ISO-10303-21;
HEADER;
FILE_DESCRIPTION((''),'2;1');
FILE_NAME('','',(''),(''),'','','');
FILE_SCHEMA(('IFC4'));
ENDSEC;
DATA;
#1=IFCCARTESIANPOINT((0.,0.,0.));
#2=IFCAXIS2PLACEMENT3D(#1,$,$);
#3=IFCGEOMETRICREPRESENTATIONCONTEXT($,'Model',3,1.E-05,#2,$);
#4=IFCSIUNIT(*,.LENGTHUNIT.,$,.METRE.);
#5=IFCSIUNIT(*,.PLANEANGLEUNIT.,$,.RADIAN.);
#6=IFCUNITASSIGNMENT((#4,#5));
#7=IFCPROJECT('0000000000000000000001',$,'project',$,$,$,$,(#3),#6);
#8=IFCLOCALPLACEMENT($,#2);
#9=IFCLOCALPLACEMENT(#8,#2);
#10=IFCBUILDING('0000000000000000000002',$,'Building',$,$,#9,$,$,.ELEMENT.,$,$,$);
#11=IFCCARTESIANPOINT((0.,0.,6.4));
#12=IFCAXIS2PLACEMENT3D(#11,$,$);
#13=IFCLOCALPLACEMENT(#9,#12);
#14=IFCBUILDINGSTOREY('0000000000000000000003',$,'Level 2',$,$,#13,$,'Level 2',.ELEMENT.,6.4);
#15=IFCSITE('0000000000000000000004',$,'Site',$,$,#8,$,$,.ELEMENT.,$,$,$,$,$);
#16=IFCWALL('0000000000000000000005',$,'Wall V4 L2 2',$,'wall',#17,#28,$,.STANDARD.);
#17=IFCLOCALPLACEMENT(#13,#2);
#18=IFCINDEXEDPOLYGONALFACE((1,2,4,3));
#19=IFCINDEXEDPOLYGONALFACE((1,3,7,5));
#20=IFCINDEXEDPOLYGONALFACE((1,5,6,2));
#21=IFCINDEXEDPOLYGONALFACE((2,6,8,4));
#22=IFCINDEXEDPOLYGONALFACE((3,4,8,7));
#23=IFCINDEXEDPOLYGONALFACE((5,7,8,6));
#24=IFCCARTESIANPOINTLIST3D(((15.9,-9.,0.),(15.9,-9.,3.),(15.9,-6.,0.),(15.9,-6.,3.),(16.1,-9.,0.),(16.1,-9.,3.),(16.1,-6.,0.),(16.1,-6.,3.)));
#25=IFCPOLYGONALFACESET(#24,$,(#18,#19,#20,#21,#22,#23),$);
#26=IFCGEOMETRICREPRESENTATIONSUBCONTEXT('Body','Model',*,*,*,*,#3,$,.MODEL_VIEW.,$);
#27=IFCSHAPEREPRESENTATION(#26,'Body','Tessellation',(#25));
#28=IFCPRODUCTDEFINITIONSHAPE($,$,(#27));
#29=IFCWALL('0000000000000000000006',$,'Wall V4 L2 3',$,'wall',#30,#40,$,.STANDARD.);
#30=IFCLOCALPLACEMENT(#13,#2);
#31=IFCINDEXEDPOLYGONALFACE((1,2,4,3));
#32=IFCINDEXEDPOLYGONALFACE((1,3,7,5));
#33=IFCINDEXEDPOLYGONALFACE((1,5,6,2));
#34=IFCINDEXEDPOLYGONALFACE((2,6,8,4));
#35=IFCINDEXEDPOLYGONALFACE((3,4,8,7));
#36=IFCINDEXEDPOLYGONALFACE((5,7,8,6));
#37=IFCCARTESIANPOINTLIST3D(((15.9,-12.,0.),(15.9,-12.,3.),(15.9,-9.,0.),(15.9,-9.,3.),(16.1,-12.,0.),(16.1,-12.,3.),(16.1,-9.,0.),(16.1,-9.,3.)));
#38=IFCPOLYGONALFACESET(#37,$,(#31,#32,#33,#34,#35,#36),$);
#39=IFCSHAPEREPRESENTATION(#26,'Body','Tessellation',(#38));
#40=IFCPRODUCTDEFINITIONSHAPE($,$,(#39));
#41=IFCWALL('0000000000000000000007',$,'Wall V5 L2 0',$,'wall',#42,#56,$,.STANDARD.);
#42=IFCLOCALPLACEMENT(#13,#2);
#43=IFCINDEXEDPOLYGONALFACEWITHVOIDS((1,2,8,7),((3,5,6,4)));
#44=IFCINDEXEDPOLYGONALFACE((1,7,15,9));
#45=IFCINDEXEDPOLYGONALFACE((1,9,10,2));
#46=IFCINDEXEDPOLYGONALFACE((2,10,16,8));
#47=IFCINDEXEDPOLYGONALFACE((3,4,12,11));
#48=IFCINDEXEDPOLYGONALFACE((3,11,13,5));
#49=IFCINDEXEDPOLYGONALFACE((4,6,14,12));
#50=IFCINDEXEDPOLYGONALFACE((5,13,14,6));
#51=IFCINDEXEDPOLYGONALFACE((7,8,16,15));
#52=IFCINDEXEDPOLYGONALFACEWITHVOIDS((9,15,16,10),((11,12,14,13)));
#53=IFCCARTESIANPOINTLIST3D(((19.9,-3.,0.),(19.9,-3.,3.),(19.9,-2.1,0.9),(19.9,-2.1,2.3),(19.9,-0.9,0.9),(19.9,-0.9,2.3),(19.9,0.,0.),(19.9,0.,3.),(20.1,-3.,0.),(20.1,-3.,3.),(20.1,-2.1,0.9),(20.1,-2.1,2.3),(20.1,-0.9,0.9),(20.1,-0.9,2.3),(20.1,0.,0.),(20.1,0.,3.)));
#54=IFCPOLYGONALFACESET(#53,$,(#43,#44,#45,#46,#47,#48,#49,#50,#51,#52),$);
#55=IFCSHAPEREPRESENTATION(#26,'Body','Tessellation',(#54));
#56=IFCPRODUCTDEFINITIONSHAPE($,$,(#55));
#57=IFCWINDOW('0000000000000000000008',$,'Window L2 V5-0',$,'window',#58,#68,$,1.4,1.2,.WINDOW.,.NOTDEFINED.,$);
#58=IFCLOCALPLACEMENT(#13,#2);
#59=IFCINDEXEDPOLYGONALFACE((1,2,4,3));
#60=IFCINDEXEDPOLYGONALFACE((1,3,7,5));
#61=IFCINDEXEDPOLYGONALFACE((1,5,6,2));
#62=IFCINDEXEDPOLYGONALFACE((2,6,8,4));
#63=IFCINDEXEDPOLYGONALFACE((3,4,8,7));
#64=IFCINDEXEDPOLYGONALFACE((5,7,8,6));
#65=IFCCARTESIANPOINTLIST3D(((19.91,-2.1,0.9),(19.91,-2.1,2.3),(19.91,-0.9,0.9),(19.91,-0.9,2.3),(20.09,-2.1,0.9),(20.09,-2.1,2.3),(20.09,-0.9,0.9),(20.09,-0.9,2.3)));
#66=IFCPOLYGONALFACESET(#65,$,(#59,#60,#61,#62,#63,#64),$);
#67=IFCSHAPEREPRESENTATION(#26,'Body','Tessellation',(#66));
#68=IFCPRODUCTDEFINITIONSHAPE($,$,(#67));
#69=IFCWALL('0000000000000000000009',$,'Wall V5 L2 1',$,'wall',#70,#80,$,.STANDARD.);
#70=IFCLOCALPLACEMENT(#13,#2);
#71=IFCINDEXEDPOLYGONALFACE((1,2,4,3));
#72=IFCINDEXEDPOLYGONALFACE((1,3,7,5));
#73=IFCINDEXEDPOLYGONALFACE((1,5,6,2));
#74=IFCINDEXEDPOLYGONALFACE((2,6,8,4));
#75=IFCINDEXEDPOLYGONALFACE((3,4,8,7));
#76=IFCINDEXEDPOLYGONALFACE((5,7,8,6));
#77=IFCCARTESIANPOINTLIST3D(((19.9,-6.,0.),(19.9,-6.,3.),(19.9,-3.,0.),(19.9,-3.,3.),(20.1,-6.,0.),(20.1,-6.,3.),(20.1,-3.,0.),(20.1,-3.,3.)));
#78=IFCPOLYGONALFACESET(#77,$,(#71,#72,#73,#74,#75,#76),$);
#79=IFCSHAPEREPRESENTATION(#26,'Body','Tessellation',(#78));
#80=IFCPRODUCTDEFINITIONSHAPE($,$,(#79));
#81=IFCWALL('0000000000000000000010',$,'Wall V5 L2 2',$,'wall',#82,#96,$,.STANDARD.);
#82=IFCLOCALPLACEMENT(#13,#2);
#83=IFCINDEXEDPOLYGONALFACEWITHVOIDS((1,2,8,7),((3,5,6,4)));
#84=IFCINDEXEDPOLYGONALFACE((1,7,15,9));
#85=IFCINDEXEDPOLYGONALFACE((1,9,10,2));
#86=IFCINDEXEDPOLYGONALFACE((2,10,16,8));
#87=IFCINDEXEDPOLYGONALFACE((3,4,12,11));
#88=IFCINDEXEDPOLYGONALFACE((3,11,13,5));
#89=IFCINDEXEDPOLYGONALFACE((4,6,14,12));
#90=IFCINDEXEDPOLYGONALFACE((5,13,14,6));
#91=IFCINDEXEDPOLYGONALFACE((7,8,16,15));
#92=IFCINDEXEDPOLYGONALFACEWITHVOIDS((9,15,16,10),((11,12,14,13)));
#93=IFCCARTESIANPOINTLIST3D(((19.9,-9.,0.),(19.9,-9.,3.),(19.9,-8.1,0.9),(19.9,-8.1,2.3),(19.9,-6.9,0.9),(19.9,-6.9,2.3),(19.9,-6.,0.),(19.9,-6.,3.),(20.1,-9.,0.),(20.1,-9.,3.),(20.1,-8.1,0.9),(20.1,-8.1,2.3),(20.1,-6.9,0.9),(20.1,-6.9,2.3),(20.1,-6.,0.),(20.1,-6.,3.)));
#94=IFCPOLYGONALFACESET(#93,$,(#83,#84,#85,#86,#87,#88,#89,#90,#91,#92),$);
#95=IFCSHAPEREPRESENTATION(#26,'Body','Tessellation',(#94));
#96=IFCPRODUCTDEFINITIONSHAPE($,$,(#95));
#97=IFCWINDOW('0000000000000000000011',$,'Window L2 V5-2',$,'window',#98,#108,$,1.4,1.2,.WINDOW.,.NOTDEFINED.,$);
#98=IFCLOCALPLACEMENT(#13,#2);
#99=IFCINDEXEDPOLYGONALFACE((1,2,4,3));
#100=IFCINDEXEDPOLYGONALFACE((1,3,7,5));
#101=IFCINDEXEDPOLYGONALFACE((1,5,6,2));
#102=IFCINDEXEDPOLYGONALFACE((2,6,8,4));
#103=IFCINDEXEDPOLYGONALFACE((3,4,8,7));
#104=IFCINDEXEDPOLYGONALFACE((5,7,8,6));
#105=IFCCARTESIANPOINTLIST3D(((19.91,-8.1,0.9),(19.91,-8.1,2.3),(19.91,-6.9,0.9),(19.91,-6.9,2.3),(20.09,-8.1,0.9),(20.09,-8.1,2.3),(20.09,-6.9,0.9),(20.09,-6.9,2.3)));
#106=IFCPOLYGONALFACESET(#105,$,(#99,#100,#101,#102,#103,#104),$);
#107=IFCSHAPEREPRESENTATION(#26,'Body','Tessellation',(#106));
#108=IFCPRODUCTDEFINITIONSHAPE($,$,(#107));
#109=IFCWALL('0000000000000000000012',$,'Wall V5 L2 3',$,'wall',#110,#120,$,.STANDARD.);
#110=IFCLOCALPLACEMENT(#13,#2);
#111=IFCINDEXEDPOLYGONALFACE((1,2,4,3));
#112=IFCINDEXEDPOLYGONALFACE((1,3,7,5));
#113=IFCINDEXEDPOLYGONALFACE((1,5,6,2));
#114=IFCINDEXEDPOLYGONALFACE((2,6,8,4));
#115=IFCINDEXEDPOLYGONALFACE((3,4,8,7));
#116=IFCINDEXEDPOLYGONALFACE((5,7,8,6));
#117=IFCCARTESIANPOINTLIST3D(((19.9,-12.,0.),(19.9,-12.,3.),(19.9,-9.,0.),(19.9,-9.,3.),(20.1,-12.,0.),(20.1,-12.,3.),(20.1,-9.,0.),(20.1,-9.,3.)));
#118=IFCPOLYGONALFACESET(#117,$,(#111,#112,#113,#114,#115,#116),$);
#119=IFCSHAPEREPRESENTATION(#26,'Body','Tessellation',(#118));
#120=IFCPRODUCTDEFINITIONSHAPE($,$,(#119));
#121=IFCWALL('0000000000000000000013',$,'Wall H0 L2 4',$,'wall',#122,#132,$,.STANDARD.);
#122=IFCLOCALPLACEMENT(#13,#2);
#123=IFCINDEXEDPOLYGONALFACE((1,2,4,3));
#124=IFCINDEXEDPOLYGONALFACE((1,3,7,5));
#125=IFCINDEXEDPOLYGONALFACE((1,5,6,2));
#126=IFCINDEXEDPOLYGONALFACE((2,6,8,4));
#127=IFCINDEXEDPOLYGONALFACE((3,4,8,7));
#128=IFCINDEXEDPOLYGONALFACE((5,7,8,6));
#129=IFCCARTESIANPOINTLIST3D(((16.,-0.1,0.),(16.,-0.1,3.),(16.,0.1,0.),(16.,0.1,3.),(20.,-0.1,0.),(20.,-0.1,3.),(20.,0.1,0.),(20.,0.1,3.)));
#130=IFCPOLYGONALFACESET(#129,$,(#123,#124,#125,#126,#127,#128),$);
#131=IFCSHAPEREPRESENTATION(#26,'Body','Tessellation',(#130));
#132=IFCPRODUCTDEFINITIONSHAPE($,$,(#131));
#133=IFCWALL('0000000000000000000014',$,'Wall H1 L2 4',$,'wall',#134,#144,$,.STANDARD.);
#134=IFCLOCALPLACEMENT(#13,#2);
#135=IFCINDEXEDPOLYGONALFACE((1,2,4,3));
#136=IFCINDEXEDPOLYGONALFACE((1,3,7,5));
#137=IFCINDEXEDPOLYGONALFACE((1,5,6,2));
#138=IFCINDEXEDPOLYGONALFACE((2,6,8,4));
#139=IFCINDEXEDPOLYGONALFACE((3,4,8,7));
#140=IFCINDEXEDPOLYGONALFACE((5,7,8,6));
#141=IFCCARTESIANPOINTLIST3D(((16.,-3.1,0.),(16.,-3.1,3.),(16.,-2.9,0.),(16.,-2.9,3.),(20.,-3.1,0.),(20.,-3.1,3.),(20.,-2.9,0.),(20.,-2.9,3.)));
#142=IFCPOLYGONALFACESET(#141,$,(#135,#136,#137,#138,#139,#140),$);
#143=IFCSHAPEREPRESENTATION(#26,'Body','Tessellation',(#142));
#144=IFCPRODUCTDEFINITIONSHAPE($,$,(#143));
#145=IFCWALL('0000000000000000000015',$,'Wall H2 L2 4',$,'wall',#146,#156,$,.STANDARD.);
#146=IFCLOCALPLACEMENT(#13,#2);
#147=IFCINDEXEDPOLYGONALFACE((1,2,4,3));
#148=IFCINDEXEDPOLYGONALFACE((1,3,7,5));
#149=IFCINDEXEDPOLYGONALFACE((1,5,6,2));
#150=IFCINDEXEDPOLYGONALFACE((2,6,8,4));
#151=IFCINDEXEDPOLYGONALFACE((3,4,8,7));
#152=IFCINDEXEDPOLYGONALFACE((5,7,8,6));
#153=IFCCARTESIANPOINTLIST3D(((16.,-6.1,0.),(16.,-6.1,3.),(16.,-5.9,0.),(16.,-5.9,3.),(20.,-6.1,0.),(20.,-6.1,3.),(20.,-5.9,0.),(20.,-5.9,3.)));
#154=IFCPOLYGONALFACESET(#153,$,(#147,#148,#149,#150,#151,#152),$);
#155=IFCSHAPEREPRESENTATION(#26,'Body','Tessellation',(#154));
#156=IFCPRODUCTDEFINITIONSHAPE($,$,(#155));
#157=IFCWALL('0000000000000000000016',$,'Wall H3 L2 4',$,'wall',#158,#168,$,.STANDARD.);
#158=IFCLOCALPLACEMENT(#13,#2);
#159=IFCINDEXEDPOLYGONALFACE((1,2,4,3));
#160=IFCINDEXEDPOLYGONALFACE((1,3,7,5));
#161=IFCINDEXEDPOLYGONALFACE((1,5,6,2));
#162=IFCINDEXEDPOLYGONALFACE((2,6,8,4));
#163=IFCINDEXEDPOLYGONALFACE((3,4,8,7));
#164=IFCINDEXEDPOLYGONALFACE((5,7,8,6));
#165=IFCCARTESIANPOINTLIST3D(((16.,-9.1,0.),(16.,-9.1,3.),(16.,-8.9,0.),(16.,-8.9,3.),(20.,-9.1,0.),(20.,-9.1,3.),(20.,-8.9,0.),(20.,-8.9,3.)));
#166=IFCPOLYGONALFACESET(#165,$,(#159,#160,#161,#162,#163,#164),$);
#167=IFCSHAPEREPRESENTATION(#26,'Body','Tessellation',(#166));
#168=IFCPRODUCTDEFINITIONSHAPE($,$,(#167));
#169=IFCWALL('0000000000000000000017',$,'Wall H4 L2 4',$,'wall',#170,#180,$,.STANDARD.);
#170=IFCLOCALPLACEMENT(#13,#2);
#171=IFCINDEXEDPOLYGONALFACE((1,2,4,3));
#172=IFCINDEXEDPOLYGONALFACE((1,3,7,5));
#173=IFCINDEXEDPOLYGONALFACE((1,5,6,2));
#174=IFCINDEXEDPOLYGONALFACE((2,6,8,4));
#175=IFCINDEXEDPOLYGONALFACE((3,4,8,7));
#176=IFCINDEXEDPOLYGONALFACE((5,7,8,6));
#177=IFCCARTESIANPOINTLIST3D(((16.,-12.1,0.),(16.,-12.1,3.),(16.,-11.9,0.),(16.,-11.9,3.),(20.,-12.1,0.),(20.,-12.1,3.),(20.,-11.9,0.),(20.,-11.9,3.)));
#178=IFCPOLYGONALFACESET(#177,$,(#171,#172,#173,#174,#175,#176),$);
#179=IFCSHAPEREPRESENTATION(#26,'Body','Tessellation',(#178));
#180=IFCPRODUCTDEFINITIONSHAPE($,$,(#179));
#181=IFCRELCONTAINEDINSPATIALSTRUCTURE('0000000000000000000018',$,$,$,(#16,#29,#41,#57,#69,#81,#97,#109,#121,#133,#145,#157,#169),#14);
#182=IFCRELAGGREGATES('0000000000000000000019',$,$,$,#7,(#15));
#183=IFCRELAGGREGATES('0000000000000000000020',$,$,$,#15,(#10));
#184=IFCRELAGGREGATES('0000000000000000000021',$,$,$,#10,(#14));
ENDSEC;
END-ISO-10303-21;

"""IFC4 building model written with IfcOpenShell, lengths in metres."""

from ifc_helpers import new_model, si_unit, frame, frame_2d, origin, origin_2d, place, context, subcontext, project, spatial, rectangle, extrude, element, fill, save


model = new_model("IFC4")

# Units and contexts
model_context = context("Model", 3, precision=1e-05, world=origin())
body_context = subcontext(model_context, "Body", "Model", "MODEL_VIEW")
ifc_project = project(units=[si_unit("LENGTHUNIT", "METRE"), si_unit("PLANEANGLEUNIT", "RADIAN")], contexts=[model_context])

# Site, building, storey
site_placement = place(None, origin())
site = spatial("IfcSite", under=ifc_project, at=site_placement, Name="Site", CompositionType="ELEMENT")
building_placement = place(site_placement, origin())
building = spatial("IfcBuilding", under=site, at=building_placement, Name="Building", CompositionType="ELEMENT")
storey_placement = place(building_placement, frame((0.0, 0.0, 6.4)))
storey = spatial("IfcBuildingStorey", under=building, at=storey_placement, Name="Level 2", LongName="Level 2", CompositionType="ELEMENT", Elevation=6.4)

# Walls
for number, where, z_axis, x_axis, name in (
    (1, (16.0, -6.0, 0.0), (0.0, 0.0, 1.0), (0.0, -1.0, 0.0), "Wall V4 L2 2"),
    (2, (16.0, -9.0, 0.0), (0.0, 0.0, 1.0), (0.0, -1.0, 0.0), "Wall V4 L2 3"),
):
    element("IfcWall", number, at=place(storey_placement, frame(where, z_axis=z_axis, x_axis=x_axis)), inside=storey, Name=name, ObjectType="wall", PredefinedType="STANDARD", context=body_context, shape_type="SweptSolid", body=[
        extrude(rectangle(XDim=3.0, YDim=0.2, at=frame_2d((1.5, 0.0))), origin(), (0.0, 0.0, 1.0), 3.0),
    ])

# Wall, opening, window
wall_1_placement = place(storey_placement, frame((20.0, 0.0, 0.0), z_axis=(0.0, 0.0, 1.0), x_axis=(0.0, -1.0, 0.0)))
wall_1 = element("IfcWall", 3, at=wall_1_placement, inside=storey, Name="Wall V5 L2 0", ObjectType="wall", PredefinedType="STANDARD", context=body_context, shape_type="SweptSolid", body=[
    extrude(rectangle(XDim=3.0, YDim=0.2, at=frame_2d((1.5, 0.0))), origin(), (0.0, 0.0, 1.0), 3.0),
])
opening_1_placement = place(storey_placement, frame((20.0, -1.5, 0.9), z_axis=(0.0, 0.0, 1.0), x_axis=(0.0, -1.0, 0.0)))
opening_1 = element("IfcOpeningElement", 4, at=opening_1_placement, cuts=wall_1, ObjectType="Opening", PredefinedType="OPENING", context=body_context, shape_type="SweptSolid", body=[
    extrude(rectangle(XDim=1.2, YDim=0.22, at=origin_2d()), origin(), (0.0, 0.0, 1.0), 1.4),
])
window_1_placement = place(storey_placement, frame((20.0, -1.5, 0.9), z_axis=(0.0, 0.0, 1.0), x_axis=(0.0, -1.0, 0.0)))
window_1 = element("IfcWindow", 5, at=window_1_placement, inside=storey, Name="Window L2 V5-0", ObjectType="window", OverallHeight=1.4, OverallWidth=1.2, PartitioningType="NOTDEFINED", PredefinedType="WINDOW", context=body_context, shape_type="SweptSolid", body=[
    extrude(rectangle(XDim=1.2, YDim=0.18, at=origin_2d()), origin(), (0.0, 0.0, 1.0), 1.4),
])
fill(opening_1, window_1)

# Wall
wall_2_placement = place(storey_placement, frame((20.0, -3.0, 0.0), z_axis=(0.0, 0.0, 1.0), x_axis=(0.0, -1.0, 0.0)))
element("IfcWall", 6, at=wall_2_placement, inside=storey, Name="Wall V5 L2 1", ObjectType="wall", PredefinedType="STANDARD", context=body_context, shape_type="SweptSolid", body=[
    extrude(rectangle(XDim=3.0, YDim=0.2, at=frame_2d((1.5, 0.0))), origin(), (0.0, 0.0, 1.0), 3.0),
])

# Wall, opening, window
wall_3_placement = place(storey_placement, frame((20.0, -6.0, 0.0), z_axis=(0.0, 0.0, 1.0), x_axis=(0.0, -1.0, 0.0)))
wall_3 = element("IfcWall", 7, at=wall_3_placement, inside=storey, Name="Wall V5 L2 2", ObjectType="wall", PredefinedType="STANDARD", context=body_context, shape_type="SweptSolid", body=[
    extrude(rectangle(XDim=3.0, YDim=0.2, at=frame_2d((1.5, 0.0))), origin(), (0.0, 0.0, 1.0), 3.0),
])
opening_2_placement = place(storey_placement, frame((20.0, -7.5, 0.9), z_axis=(0.0, 0.0, 1.0), x_axis=(0.0, -1.0, 0.0)))
opening_2 = element("IfcOpeningElement", 8, at=opening_2_placement, cuts=wall_3, ObjectType="Opening", PredefinedType="OPENING", context=body_context, shape_type="SweptSolid", body=[
    extrude(rectangle(XDim=1.2, YDim=0.22, at=origin_2d()), origin(), (0.0, 0.0, 1.0), 1.4),
])
window_2_placement = place(storey_placement, frame((20.0, -7.5, 0.9), z_axis=(0.0, 0.0, 1.0), x_axis=(0.0, -1.0, 0.0)))
window_2 = element("IfcWindow", 9, at=window_2_placement, inside=storey, Name="Window L2 V5-2", ObjectType="window", OverallHeight=1.4, OverallWidth=1.2, PartitioningType="NOTDEFINED", PredefinedType="WINDOW", context=body_context, shape_type="SweptSolid", body=[
    extrude(rectangle(XDim=1.2, YDim=0.18, at=origin_2d()), origin(), (0.0, 0.0, 1.0), 1.4),
])
fill(opening_2, window_2)

# Walls
wall_4_placement = place(storey_placement, frame((20.0, -9.0, 0.0), z_axis=(0.0, 0.0, 1.0), x_axis=(0.0, -1.0, 0.0)))
element("IfcWall", 10, at=wall_4_placement, inside=storey, Name="Wall V5 L2 3", ObjectType="wall", PredefinedType="STANDARD", context=body_context, shape_type="SweptSolid", body=[
    extrude(rectangle(XDim=3.0, YDim=0.2, at=frame_2d((1.5, 0.0))), origin(), (0.0, 0.0, 1.0), 3.0),
])
for number, where, z_axis, x_axis, name in (
    (11, (16.0, 0.0, 0.0), (0.0, 0.0, 1.0), (1.0, 0.0, 0.0), "Wall H0 L2 4"),
    (12, (16.0, -3.0, 0.0), (0.0, 0.0, 1.0), (1.0, 0.0, 0.0), "Wall H1 L2 4"),
    (13, (16.0, -6.0, 0.0), (0.0, 0.0, 1.0), (1.0, 0.0, 0.0), "Wall H2 L2 4"),
    (14, (16.0, -9.0, 0.0), (0.0, 0.0, 1.0), (1.0, 0.0, 0.0), "Wall H3 L2 4"),
    (15, (16.0, -12.0, 0.0), (0.0, 0.0, 1.0), (1.0, 0.0, 0.0), "Wall H4 L2 4"),
):
    element("IfcWall", number, at=place(storey_placement, frame(where, z_axis=z_axis, x_axis=x_axis)), inside=storey, Name=name, ObjectType="wall", PredefinedType="STANDARD", context=body_context, shape_type="SweptSolid", body=[
        extrude(rectangle(XDim=4.0, YDim=0.2, at=frame_2d((2.0, 0.0))), origin(), (0.0, 0.0, 1.0), 3.0),
    ])

save(model, "model.ifc")
